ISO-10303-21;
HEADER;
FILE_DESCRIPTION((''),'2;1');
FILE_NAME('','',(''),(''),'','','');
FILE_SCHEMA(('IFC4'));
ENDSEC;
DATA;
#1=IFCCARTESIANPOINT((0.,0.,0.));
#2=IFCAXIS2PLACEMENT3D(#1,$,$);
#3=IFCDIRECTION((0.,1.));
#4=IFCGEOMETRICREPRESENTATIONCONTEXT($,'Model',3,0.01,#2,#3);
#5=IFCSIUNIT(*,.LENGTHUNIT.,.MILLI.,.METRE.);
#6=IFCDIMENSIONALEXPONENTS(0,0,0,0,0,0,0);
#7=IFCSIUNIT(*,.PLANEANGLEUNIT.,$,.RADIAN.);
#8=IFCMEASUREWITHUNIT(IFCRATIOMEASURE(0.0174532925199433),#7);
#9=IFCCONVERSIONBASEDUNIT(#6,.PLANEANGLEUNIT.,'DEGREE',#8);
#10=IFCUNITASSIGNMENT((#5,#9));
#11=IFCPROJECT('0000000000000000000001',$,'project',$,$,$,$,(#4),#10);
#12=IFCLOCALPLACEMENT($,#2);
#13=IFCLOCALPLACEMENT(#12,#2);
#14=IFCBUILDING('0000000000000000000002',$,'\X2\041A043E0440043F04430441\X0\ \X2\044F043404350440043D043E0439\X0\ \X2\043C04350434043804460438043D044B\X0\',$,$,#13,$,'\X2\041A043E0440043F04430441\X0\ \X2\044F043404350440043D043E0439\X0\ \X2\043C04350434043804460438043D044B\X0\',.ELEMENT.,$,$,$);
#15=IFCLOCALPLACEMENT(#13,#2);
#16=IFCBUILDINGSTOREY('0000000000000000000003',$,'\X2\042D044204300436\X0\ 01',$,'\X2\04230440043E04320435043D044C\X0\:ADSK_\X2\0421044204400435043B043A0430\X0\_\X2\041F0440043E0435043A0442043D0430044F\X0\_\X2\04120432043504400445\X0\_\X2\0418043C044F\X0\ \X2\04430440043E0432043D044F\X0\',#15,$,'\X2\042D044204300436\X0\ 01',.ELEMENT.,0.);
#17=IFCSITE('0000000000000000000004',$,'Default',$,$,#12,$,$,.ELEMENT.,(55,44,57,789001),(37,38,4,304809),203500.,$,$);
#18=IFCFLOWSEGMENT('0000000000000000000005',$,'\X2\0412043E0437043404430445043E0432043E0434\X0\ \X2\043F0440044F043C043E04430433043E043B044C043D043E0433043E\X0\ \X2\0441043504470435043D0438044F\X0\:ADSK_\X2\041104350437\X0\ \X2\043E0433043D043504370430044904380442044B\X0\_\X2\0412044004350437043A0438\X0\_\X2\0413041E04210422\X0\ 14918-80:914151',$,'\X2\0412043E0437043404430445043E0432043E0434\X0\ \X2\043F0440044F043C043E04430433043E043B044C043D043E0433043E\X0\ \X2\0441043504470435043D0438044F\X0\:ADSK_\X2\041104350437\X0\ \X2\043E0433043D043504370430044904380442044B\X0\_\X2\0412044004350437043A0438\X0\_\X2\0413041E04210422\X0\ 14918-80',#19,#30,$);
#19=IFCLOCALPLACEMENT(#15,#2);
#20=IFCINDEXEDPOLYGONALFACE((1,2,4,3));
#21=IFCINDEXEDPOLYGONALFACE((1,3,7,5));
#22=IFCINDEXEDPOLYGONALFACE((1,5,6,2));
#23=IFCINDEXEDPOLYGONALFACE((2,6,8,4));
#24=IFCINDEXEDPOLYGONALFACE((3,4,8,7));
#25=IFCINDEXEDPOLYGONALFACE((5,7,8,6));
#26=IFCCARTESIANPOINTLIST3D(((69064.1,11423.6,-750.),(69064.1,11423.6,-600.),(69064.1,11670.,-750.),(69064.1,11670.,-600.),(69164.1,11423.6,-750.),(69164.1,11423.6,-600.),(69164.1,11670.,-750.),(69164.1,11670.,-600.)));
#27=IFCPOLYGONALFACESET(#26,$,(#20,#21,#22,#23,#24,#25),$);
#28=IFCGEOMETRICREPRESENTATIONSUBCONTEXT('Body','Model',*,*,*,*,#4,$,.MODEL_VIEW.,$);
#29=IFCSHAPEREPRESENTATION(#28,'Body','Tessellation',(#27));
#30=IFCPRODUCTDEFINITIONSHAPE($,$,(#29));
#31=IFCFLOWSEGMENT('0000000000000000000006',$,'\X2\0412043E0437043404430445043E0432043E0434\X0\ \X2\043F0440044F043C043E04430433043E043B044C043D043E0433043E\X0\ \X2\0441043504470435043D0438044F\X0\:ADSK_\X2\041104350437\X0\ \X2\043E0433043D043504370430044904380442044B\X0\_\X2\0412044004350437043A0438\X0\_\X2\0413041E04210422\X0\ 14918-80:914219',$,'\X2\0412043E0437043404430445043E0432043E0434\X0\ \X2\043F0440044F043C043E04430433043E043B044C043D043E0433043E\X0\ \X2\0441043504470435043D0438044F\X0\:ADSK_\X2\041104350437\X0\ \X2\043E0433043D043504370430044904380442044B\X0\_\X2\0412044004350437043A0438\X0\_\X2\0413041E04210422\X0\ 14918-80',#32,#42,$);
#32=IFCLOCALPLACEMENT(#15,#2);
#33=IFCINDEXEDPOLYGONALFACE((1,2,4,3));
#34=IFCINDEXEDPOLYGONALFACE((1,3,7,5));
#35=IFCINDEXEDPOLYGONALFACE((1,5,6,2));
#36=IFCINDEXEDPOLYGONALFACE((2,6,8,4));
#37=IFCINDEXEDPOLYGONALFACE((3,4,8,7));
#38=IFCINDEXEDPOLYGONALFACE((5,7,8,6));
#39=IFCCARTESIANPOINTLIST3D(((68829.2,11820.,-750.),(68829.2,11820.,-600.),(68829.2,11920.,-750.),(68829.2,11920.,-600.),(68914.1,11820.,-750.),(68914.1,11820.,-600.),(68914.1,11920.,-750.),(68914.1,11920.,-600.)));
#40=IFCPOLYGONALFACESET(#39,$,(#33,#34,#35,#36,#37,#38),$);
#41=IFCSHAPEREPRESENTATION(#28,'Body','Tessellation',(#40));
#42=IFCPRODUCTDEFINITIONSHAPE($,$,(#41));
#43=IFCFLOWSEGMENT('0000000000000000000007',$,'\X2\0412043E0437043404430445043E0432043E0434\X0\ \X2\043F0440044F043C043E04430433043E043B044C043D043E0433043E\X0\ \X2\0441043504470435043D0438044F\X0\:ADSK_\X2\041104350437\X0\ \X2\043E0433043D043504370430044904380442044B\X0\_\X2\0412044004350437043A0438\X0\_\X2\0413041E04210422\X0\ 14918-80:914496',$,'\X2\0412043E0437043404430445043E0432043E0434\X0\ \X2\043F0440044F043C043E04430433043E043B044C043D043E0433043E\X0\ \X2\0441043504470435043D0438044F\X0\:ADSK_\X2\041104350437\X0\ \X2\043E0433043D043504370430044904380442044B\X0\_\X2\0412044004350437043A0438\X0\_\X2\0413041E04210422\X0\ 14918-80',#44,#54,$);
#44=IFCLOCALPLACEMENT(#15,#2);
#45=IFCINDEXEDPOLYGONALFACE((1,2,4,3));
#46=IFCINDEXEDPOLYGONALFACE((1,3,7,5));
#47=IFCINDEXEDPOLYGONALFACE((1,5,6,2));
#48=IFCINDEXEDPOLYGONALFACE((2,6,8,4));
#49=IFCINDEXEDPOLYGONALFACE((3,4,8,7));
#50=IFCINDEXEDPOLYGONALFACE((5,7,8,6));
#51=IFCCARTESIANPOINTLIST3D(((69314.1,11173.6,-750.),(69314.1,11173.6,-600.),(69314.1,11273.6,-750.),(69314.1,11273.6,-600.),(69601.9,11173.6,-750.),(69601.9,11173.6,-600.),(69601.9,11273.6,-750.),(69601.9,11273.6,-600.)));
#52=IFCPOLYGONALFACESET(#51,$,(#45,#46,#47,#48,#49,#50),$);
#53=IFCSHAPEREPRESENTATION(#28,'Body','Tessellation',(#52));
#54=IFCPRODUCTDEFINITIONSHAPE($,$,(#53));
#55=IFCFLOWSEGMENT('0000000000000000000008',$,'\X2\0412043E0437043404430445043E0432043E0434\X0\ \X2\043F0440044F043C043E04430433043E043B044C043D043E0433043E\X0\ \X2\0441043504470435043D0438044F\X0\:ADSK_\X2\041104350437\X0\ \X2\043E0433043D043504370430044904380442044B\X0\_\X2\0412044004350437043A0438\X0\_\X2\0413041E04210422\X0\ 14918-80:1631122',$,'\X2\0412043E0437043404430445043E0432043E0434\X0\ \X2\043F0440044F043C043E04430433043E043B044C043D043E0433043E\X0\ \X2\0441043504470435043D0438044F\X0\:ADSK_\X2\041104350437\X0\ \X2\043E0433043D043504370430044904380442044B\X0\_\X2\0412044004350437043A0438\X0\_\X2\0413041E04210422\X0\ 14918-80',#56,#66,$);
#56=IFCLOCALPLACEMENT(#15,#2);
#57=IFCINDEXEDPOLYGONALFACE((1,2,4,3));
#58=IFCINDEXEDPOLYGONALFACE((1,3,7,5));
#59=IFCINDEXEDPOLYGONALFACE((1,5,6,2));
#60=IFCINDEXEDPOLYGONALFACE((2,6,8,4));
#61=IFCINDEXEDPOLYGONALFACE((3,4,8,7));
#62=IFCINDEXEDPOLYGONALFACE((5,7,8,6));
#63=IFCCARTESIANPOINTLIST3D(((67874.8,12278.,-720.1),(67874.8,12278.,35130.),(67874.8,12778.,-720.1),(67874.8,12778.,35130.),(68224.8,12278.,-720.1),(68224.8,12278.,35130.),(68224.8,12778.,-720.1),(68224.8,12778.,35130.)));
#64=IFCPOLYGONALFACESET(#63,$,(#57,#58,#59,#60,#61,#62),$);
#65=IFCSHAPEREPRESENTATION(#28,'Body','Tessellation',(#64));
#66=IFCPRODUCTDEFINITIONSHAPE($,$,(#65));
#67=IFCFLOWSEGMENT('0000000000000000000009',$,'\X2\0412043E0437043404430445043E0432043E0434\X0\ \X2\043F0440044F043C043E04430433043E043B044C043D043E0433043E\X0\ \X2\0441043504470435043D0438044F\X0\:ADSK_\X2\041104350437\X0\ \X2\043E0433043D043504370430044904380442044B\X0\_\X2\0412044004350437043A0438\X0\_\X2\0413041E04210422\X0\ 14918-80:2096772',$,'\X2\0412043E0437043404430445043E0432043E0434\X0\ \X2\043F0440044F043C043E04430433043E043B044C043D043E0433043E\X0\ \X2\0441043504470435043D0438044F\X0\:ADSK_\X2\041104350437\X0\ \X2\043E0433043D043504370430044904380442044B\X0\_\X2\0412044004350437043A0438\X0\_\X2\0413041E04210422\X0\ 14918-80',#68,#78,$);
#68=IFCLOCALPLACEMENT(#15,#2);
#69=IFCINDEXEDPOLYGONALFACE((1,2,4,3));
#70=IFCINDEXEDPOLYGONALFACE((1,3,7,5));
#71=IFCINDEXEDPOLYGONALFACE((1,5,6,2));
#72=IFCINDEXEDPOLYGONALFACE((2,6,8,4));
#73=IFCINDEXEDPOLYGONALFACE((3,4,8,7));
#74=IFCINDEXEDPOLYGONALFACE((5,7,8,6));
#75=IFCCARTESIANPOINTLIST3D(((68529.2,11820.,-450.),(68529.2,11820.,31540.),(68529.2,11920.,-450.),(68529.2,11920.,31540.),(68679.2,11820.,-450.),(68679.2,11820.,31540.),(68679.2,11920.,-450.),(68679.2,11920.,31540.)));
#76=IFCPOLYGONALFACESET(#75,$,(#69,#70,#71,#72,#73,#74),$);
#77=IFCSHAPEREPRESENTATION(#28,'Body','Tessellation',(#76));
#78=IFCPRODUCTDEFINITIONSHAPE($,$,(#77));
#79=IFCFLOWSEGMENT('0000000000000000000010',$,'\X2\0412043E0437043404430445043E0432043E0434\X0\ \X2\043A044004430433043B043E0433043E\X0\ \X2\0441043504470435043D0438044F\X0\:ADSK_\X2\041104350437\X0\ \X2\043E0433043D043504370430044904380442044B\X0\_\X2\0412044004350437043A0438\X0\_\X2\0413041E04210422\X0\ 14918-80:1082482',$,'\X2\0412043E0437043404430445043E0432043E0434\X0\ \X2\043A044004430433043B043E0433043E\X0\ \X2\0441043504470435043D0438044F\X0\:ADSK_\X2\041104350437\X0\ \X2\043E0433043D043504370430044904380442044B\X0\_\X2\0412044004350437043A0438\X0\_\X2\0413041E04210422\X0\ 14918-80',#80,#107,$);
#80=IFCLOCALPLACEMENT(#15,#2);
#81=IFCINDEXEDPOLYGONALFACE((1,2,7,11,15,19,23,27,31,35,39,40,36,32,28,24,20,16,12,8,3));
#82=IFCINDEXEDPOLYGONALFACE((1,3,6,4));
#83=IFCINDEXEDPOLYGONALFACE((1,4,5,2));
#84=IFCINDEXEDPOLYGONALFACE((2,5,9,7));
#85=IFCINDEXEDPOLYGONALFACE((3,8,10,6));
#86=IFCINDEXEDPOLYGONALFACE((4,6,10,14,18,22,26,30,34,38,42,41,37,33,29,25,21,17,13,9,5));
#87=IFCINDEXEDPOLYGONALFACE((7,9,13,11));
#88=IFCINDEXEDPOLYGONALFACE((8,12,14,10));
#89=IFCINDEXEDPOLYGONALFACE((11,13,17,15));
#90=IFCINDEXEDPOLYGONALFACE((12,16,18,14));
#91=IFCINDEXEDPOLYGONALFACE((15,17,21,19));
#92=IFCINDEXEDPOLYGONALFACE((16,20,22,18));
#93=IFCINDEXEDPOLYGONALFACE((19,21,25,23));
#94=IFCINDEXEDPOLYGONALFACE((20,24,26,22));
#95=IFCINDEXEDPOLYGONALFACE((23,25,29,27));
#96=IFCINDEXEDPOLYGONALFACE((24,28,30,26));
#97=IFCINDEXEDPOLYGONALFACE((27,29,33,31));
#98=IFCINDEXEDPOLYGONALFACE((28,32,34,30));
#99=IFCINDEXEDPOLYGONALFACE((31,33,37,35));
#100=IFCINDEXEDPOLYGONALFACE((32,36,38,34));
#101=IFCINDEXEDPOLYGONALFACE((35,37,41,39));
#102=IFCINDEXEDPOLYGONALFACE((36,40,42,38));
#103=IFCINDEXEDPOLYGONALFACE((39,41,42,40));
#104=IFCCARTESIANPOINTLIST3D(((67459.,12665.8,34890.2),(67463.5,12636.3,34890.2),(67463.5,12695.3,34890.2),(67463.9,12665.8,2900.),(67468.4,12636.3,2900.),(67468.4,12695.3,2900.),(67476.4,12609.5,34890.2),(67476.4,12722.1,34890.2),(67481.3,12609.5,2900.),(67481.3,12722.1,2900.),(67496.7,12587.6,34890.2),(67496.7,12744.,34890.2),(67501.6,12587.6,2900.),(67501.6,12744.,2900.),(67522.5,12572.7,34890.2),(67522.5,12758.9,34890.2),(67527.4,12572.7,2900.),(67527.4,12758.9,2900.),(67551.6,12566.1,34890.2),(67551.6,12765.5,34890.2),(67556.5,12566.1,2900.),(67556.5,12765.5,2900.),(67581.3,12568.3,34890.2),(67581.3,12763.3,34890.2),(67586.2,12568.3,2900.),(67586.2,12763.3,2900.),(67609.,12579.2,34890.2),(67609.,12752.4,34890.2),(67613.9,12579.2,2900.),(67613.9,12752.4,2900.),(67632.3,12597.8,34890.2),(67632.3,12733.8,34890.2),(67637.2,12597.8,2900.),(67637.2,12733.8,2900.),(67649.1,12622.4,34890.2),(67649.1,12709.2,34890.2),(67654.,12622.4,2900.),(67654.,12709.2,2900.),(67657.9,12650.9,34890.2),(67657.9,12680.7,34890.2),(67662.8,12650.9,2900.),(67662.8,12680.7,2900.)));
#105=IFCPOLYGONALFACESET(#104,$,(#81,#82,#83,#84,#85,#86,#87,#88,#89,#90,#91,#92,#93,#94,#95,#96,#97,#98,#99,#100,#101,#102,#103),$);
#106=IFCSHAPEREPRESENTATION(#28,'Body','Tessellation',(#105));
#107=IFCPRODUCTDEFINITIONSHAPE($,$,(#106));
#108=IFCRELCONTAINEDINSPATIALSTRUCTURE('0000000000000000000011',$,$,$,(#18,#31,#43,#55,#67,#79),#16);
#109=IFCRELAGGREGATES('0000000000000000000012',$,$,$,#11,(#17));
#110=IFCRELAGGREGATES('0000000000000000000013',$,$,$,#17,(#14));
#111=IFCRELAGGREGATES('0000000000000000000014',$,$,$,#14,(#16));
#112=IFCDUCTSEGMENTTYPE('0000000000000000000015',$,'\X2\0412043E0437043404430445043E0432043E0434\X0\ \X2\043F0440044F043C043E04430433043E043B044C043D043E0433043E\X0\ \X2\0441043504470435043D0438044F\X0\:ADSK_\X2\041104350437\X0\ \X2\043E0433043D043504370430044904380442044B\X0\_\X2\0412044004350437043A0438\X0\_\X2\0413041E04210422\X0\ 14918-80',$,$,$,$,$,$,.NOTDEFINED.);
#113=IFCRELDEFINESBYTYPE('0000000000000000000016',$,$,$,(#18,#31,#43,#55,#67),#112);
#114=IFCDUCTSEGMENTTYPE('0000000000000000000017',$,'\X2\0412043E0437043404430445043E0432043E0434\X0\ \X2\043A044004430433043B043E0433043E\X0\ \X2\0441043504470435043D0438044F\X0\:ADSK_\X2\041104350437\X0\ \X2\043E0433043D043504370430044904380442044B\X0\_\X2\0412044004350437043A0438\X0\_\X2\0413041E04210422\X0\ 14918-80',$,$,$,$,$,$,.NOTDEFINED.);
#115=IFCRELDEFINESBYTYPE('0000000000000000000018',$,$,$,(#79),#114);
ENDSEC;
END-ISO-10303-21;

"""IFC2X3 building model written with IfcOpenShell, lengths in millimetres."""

from ifc_helpers import new_model, entity, si_unit, converted_unit, direction, frame, origin, origin_2d_with_axis, place, context, subcontext, project, spatial, rectangle, circle, extrude, type_object, element, save


model = new_model("IFC2X3")

# Units and contexts
model_context = context("Model", 3, precision=0.01, world=origin(), true_north=direction((0.0, 1.0)))
body_context = subcontext(model_context, "Body", "Model", "MODEL_VIEW")
ifc_project = project(units=[si_unit("LENGTHUNIT", "METRE", prefix="MILLI"), converted_unit("PLANEANGLEUNIT", "DEGREE", entity("IfcRatioMeasure", 0.0174532925199433), si_unit("PLANEANGLEUNIT", "RADIAN"), dimensions=[0, 0, 0, 0, 0, 0, 0])], contexts=[model_context])

# Site, building, storey
site_placement = place(None, origin())
site = spatial("IfcSite", under=ifc_project, at=site_placement, Name="Default", CompositionType="ELEMENT", RefLatitude=(55, 44, 57, 789001), RefLongitude=(37, 38, 4, 304809), RefElevation=203500.0)
building_placement = place(site_placement, origin())
building = spatial("IfcBuilding", under=site, at=building_placement, Name="Корпус ядерной медицины", LongName="Корпус ядерной медицины", CompositionType="ELEMENT")
storey_placement = place(building_placement, origin())
storey = spatial("IfcBuildingStorey", under=building, at=storey_placement, Name="Этаж 01", ObjectType="Уровень:ADSK_Стрелка_Проектная_Вверх_Имя уровня", LongName="Этаж 01", CompositionType="ELEMENT", Elevation=0.0)

# Flow segments
duct_segment_type_1 = type_object("IfcDuctSegmentType", Name="Воздуховод прямоугольного сечения:ADSK_Без огнезащиты_Врезки_ГОСТ 14918-80", PredefinedType="NOTDEFINED")
flow_segment_1_placement = place(storey_placement, frame((69064.1, 11423.6, -750.0)))
element("IfcFlowSegment", 1, at=flow_segment_1_placement, inside=storey, type_object=duct_segment_type_1, Name="Воздуховод прямоугольного сечения:ADSK_Без огнезащиты_Врезки_ГОСТ 14918-80:914151", ObjectType="Воздуховод прямоугольного сечения:ADSK_Без огнезащиты_Врезки_ГОСТ 14918-80", context=body_context, shape_type="SweptSolid", body=[
    extrude(rectangle(XDim=246.4, YDim=100.0, at=origin_2d_with_axis()), frame((50.0, 123.2, 0.0), z_axis=(0.0, 0.0, 1.0), x_axis=(0.0, -1.0, 0.0)), (0.0, 0.0, 1.0), 150.0),
])
flow_segment_2_placement = place(storey_placement, frame((68829.2, 11820.0, -750.0)))
element("IfcFlowSegment", 2, at=flow_segment_2_placement, inside=storey, type_object=duct_segment_type_1, Name="Воздуховод прямоугольного сечения:ADSK_Без огнезащиты_Врезки_ГОСТ 14918-80:914219", ObjectType="Воздуховод прямоугольного сечения:ADSK_Без огнезащиты_Врезки_ГОСТ 14918-80", context=body_context, shape_type="SweptSolid", body=[
    extrude(rectangle(XDim=84.9, YDim=100.0, at=origin_2d_with_axis()), frame((42.4, 50.0, 0.0), z_axis=(0.0, 0.0, 1.0), x_axis=(-1.0, 0.0, 0.0)), (0.0, 0.0, 1.0), 150.0),
])
flow_segment_3_placement = place(storey_placement, frame((69314.1, 11173.6, -750.0)))
element("IfcFlowSegment", 3, at=flow_segment_3_placement, inside=storey, type_object=duct_segment_type_1, Name="Воздуховод прямоугольного сечения:ADSK_Без огнезащиты_Врезки_ГОСТ 14918-80:914496", ObjectType="Воздуховод прямоугольного сечения:ADSK_Без огнезащиты_Врезки_ГОСТ 14918-80", context=body_context, shape_type="SweptSolid", body=[
    extrude(rectangle(XDim=287.8, YDim=100.0, at=origin_2d_with_axis()), frame((143.9, 50.0, 0.0)), (0.0, 0.0, 1.0), 150.0),
])
flow_segment_4_placement = place(storey_placement, frame((67874.8, 12278.0, -720.1)))
element("IfcFlowSegment", 4, at=flow_segment_4_placement, inside=storey, type_object=duct_segment_type_1, Name="Воздуховод прямоугольного сечения:ADSK_Без огнезащиты_Врезки_ГОСТ 14918-80:1631122", ObjectType="Воздуховод прямоугольного сечения:ADSK_Без огнезащиты_Врезки_ГОСТ 14918-80", context=body_context, shape_type="SweptSolid", body=[
    extrude(rectangle(XDim=500.0, YDim=350.0, at=origin_2d_with_axis()), frame((175.0, 250.0, 0.0), z_axis=(0.0, 0.0, 1.0), x_axis=(0.0, -1.0, 0.0)), (0.0, 0.0, 1.0), 35850.1),
])
flow_segment_5_placement = place(storey_placement, frame((68529.2, 11820.0, -450.0)))
element("IfcFlowSegment", 5, at=flow_segment_5_placement, inside=storey, type_object=duct_segment_type_1, Name="Воздуховод прямоугольного сечения:ADSK_Без огнезащиты_Врезки_ГОСТ 14918-80:2096772", ObjectType="Воздуховод прямоугольного сечения:ADSK_Без огнезащиты_Врезки_ГОСТ 14918-80", context=body_context, shape_type="SweptSolid", body=[
    extrude(rectangle(XDim=150.0, YDim=100.0, at=origin_2d_with_axis()), frame((75.0, 50.0, 0.0), z_axis=(0.0, 0.0, 1.0), x_axis=(-1.0, 0.0, 0.0)), (0.0, 0.0, 1.0), 31990.0),
])
duct_segment_type_2 = type_object("IfcDuctSegmentType", Name="Воздуховод круглого сечения:ADSK_Без огнезащиты_Врезки_ГОСТ 14918-80", PredefinedType="NOTDEFINED")
flow_segment_6_placement = place(storey_placement, frame((67457.4, 12564.2, 2900.0)))
element("IfcFlowSegment", 6, at=flow_segment_6_placement, inside=storey, type_object=duct_segment_type_2, Name="Воздуховод круглого сечения:ADSK_Без огнезащиты_Врезки_ГОСТ 14918-80:1082482", ObjectType="Воздуховод круглого сечения:ADSK_Без огнезащиты_Врезки_ГОСТ 14918-80", context=body_context, shape_type="SweptSolid", body=[
    extrude(circle(Radius=100.0, at=origin_2d_with_axis()), frame((106.5, 101.6, 0.0), z_axis=(-0.000153, 0.0, 1.0), x_axis=(-1.0, 0.0, -0.000153)), (0.0, 0.0, 1.0), 31990.2),
])

save(model, "model.ifc")
